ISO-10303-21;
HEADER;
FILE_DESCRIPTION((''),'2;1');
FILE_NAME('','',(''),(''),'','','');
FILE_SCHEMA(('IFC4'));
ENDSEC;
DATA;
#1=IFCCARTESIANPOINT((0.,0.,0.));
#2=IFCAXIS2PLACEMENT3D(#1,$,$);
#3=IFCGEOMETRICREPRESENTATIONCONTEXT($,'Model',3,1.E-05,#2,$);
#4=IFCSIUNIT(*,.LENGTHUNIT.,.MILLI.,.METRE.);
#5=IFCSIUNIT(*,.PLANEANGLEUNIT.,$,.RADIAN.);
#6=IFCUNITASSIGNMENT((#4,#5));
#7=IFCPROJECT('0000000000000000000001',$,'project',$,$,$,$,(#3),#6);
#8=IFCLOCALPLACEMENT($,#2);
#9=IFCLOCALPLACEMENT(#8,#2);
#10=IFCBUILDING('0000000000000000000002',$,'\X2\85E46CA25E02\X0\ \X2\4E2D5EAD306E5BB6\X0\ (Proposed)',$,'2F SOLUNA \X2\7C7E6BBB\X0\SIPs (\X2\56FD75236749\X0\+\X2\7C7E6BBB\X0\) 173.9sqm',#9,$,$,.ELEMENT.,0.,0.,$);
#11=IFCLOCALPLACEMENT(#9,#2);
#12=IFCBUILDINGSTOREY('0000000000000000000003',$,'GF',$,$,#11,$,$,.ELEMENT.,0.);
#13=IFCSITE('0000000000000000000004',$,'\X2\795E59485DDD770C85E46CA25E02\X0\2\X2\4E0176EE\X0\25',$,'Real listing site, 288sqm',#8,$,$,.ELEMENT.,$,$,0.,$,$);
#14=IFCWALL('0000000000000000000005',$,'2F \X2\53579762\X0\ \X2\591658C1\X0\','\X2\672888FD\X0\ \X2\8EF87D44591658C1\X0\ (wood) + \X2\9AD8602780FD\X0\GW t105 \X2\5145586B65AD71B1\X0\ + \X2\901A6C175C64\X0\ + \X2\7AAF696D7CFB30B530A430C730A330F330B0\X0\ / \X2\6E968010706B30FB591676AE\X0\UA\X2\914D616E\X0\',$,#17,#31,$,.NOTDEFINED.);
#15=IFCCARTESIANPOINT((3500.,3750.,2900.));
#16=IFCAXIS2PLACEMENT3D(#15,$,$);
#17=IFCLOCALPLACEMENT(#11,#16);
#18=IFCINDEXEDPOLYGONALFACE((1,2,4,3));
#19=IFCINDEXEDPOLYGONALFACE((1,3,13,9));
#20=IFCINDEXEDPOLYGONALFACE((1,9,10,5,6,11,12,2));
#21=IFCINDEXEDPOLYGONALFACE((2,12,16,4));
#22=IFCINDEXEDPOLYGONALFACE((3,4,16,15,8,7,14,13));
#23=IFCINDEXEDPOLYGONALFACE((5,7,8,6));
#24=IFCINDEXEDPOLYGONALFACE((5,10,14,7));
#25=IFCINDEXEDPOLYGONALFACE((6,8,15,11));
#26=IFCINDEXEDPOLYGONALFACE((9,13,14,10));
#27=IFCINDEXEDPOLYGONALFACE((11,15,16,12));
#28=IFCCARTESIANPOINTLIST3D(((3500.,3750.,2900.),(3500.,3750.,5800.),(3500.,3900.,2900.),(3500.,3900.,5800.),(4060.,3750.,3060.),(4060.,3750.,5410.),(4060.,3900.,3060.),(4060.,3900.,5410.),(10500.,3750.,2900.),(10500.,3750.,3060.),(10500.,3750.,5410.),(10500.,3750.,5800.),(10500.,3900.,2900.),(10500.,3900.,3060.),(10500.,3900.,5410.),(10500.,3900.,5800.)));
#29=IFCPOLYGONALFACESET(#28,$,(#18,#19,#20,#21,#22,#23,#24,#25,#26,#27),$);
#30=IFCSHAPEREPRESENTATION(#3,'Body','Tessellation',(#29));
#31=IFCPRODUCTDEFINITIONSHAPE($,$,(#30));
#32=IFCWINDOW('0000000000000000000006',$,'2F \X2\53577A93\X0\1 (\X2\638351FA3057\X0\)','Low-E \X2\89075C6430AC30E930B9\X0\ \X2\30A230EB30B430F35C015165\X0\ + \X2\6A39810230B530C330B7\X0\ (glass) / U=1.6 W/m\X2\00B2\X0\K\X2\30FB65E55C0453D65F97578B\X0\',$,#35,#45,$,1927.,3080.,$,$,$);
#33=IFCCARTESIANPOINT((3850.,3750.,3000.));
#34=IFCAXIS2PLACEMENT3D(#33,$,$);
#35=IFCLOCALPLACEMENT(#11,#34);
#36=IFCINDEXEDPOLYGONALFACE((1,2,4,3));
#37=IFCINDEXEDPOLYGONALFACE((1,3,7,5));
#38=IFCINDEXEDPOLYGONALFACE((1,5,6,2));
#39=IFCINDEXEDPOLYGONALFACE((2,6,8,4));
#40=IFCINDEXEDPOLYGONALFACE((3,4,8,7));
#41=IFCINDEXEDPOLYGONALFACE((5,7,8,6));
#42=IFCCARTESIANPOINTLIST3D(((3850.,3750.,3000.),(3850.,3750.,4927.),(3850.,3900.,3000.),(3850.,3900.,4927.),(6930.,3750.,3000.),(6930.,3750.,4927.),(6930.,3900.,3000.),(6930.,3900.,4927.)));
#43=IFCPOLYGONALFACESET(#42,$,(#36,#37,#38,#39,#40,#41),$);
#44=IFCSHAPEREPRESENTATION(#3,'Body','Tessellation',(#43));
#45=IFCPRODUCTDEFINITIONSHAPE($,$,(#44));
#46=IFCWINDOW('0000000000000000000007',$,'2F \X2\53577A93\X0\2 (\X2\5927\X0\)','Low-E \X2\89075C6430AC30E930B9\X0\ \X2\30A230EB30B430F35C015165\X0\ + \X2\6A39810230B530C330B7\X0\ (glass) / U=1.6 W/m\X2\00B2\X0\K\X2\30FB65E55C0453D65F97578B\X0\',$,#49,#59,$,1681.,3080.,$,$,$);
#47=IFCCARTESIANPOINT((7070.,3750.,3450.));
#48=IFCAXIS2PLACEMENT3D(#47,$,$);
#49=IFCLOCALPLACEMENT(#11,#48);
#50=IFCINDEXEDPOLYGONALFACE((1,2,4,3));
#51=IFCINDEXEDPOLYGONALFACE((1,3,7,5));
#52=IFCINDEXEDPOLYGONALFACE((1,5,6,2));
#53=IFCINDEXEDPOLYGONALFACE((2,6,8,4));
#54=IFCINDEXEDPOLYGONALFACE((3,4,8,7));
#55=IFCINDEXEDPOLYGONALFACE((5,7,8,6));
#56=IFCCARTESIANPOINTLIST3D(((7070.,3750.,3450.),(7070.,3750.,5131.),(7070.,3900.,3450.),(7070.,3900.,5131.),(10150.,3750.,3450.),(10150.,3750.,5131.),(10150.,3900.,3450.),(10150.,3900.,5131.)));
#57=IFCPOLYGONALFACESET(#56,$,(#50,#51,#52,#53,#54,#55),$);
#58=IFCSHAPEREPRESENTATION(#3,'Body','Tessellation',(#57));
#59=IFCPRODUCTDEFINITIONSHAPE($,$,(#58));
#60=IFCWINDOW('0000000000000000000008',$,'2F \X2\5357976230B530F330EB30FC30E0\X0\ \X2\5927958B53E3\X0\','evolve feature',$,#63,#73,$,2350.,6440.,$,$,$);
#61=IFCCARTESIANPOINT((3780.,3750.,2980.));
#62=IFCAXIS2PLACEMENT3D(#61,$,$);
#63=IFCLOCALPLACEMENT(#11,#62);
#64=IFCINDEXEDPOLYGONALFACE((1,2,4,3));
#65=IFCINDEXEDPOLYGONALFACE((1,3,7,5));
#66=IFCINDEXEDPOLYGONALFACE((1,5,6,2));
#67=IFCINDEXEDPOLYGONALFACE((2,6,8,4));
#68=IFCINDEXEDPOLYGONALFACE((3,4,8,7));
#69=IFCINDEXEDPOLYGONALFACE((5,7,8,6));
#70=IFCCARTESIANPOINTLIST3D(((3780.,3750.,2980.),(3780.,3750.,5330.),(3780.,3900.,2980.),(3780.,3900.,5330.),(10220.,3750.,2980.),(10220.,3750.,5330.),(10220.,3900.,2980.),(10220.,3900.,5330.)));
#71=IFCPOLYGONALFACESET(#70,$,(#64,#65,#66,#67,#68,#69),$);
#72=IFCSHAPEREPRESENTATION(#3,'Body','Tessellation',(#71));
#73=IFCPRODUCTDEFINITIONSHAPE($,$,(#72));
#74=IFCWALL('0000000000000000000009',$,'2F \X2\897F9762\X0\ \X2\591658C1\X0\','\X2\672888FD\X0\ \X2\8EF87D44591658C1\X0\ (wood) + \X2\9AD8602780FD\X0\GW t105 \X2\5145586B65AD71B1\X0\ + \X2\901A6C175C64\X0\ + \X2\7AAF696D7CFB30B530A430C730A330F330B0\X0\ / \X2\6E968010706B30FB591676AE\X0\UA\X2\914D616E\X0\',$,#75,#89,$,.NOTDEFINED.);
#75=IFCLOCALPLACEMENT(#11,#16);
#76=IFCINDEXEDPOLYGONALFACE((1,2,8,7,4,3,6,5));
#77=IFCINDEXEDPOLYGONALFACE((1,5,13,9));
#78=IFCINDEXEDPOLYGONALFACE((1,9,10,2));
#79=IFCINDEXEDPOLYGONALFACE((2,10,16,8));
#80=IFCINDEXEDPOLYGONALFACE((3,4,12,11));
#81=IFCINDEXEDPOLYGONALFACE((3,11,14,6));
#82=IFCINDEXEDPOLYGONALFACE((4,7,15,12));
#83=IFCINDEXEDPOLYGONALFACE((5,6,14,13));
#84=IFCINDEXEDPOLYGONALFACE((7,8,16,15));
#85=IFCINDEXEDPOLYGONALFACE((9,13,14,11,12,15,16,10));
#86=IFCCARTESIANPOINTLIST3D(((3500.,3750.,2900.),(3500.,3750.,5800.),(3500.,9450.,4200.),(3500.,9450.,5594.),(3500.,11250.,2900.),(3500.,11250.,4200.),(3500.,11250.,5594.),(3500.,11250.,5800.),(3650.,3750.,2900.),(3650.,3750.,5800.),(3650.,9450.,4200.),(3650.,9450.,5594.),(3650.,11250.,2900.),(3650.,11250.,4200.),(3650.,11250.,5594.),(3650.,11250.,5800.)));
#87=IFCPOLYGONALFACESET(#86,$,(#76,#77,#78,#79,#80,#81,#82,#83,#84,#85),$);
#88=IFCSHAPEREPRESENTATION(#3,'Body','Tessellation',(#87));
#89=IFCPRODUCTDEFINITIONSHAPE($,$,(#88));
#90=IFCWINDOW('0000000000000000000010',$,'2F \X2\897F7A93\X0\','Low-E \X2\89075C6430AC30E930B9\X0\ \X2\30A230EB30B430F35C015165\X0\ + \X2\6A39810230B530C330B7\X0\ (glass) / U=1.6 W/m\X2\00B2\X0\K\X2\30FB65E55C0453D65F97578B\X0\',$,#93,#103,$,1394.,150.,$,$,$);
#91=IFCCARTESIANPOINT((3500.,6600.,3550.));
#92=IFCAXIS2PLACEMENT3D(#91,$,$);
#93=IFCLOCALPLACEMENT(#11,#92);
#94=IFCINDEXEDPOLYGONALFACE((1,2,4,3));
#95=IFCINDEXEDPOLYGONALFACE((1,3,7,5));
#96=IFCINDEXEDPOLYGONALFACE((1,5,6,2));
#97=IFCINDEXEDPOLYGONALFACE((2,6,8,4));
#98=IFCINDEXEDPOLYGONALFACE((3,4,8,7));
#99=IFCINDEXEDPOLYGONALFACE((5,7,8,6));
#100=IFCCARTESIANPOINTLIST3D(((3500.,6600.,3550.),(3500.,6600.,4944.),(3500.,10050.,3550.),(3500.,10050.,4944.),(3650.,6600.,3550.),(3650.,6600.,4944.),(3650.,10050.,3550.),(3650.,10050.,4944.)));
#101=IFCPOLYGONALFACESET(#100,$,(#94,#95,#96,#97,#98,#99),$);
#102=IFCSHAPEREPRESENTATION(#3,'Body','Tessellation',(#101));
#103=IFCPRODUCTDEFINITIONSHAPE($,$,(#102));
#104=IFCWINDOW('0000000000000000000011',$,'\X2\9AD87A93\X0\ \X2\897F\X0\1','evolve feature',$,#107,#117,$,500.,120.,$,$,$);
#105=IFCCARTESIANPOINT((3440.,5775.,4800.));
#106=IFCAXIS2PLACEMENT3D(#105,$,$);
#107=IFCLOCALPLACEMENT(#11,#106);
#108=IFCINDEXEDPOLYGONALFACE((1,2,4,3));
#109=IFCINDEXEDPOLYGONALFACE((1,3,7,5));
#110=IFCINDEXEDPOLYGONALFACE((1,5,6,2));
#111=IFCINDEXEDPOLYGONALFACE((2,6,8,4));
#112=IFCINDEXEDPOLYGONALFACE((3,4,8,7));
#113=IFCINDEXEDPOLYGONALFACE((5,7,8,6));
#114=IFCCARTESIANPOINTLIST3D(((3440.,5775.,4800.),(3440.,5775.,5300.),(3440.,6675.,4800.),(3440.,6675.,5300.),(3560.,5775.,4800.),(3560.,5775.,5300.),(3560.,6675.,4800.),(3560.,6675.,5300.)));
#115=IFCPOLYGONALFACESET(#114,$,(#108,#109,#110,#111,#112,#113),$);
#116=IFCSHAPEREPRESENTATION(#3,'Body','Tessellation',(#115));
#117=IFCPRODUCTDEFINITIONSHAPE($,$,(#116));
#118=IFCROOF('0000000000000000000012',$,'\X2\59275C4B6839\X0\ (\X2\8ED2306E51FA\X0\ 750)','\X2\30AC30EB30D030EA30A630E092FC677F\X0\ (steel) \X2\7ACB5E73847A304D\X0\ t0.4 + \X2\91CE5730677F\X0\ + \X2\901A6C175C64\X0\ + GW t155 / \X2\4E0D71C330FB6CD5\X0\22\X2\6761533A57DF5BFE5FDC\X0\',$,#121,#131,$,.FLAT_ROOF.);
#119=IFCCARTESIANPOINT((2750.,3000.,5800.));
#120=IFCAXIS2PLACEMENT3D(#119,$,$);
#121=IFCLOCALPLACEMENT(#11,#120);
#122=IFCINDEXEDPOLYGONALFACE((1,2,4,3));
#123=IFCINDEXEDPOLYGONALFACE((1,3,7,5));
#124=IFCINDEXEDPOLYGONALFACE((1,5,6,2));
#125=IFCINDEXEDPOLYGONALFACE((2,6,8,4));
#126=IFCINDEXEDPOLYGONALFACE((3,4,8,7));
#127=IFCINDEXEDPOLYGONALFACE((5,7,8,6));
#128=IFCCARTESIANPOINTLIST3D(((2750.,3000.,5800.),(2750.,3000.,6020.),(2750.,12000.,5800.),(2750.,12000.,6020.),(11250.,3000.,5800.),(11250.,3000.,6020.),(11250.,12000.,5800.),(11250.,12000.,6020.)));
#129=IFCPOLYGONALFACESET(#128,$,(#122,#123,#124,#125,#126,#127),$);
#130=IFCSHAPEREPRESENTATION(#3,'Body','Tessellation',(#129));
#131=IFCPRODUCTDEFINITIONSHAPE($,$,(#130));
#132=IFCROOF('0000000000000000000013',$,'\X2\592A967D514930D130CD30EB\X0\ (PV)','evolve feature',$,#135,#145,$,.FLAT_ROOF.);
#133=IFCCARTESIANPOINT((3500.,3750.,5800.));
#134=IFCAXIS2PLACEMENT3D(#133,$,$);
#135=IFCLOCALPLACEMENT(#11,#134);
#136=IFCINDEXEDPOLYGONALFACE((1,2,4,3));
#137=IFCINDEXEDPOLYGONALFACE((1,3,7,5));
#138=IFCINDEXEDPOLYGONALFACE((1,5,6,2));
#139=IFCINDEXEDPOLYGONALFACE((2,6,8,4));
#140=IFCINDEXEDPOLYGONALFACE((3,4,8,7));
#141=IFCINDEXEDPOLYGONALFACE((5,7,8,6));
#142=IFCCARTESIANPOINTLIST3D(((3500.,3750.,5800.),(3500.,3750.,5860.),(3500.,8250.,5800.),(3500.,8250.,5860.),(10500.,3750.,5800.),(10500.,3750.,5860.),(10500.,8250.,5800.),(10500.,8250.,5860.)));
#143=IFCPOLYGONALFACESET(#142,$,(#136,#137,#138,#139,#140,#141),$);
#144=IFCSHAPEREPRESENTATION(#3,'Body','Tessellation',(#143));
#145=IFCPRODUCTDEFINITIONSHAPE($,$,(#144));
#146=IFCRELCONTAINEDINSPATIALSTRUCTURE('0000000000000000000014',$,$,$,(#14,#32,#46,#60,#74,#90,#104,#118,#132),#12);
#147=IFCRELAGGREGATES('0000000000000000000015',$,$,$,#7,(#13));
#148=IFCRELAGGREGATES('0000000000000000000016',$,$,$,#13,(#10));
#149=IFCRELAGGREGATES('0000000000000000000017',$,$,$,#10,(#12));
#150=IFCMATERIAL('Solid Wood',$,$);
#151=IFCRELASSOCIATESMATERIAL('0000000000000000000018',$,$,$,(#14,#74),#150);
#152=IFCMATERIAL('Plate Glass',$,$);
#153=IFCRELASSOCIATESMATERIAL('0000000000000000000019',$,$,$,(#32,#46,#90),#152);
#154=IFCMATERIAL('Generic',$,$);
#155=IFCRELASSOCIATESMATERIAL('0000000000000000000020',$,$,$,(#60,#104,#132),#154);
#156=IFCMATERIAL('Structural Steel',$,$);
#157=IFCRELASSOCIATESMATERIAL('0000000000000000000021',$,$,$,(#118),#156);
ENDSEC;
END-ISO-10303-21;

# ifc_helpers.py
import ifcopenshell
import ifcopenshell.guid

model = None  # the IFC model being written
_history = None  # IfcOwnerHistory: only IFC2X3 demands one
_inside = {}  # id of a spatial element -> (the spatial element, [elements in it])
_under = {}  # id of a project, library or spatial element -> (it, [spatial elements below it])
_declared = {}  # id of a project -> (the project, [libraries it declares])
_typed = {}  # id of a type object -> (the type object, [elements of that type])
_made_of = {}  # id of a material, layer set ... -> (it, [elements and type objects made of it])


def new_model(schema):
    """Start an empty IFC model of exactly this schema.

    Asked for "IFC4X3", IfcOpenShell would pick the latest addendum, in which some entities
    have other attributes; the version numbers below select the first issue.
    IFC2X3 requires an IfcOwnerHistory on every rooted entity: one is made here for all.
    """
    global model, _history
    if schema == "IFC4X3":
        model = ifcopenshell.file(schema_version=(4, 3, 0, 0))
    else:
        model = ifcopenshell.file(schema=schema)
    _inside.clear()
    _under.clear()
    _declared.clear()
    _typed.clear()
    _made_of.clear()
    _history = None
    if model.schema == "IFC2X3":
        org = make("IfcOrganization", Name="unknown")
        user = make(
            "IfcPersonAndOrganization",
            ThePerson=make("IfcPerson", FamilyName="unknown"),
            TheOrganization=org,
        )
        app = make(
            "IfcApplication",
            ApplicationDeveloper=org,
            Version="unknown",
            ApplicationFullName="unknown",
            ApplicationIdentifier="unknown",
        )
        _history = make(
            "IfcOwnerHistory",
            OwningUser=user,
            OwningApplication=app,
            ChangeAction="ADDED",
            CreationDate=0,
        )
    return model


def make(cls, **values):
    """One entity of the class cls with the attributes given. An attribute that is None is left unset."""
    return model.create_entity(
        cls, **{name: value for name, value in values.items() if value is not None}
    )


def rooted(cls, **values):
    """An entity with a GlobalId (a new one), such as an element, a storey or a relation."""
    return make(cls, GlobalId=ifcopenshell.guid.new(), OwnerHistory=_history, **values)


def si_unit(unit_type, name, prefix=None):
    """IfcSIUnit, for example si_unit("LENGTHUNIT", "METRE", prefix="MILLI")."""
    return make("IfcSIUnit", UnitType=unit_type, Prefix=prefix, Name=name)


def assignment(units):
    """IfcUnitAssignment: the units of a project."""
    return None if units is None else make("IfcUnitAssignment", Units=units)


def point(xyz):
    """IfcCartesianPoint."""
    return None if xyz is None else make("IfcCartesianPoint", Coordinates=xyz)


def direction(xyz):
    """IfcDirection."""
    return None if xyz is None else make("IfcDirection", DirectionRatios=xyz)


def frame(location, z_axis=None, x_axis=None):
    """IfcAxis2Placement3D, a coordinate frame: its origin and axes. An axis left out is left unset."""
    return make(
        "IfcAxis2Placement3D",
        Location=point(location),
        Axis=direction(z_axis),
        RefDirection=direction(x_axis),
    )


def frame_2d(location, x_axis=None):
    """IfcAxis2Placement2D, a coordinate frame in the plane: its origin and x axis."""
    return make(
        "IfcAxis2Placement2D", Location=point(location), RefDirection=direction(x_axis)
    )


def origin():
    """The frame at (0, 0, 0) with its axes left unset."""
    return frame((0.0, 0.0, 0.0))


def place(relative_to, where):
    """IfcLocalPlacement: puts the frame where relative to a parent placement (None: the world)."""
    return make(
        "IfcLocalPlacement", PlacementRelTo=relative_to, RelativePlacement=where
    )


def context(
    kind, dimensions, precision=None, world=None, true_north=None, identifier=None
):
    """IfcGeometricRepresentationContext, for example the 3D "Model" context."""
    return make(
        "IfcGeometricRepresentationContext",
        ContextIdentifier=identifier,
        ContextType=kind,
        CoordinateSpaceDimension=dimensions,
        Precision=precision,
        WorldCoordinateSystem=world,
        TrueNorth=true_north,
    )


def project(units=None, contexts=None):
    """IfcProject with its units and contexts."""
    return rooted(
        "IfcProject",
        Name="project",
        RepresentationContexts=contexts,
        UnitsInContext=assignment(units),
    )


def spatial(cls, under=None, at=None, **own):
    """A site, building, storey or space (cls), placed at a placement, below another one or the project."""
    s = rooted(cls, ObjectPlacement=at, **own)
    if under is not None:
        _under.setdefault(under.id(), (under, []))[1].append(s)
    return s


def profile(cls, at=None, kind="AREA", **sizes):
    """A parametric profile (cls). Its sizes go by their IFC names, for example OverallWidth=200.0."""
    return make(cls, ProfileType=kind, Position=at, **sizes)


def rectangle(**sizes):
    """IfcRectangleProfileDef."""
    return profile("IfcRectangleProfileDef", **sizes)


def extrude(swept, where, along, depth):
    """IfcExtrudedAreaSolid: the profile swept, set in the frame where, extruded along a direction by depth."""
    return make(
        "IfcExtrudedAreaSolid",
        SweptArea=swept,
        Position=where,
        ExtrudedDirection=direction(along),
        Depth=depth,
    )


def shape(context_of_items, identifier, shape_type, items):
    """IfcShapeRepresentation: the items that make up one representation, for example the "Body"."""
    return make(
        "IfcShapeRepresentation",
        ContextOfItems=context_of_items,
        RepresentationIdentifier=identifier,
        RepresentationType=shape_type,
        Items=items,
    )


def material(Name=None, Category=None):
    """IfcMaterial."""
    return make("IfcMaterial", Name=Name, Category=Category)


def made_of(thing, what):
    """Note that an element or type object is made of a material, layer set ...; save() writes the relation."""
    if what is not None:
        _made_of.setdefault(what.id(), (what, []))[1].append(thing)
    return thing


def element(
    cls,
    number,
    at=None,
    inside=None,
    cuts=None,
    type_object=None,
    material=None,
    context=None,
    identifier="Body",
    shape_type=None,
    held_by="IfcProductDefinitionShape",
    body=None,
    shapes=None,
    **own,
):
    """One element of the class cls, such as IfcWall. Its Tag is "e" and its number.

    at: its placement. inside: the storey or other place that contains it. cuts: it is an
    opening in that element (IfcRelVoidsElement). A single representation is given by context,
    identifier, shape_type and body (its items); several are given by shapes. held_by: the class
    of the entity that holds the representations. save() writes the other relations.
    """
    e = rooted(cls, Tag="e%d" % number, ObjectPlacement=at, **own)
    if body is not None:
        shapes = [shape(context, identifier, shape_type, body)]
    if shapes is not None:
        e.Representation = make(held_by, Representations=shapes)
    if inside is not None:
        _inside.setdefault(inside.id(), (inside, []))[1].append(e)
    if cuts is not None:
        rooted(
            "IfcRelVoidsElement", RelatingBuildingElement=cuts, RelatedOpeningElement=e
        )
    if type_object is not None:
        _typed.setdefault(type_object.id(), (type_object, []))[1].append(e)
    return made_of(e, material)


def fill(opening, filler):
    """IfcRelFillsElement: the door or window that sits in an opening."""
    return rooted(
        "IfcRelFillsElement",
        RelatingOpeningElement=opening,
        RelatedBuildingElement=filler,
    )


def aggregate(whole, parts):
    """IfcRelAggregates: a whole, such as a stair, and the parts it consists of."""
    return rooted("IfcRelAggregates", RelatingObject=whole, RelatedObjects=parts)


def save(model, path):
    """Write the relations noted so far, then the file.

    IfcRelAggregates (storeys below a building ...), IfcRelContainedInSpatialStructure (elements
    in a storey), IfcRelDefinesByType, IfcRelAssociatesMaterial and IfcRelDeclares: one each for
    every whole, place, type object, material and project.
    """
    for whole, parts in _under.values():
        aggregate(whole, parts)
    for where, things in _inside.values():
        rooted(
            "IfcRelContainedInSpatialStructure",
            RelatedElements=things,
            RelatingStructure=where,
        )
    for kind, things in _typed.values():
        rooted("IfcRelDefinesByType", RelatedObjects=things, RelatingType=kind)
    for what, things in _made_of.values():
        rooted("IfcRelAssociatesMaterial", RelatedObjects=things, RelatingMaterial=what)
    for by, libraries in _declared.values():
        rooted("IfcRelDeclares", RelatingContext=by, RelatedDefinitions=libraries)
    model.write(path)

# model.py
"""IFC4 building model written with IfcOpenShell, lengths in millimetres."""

from ifc_helpers import new_model, si_unit, frame, frame_2d, origin, place, context, project, spatial, rectangle, extrude, material, element, fill, save


model = new_model("IFC4")

# Units and contexts
model_context = context("Model", 3, precision=1e-05, world=origin())
ifc_project = project(units=[si_unit("LENGTHUNIT", "METRE", prefix="MILLI"), si_unit("PLANEANGLEUNIT", "RADIAN")], contexts=[model_context])

# Site, building, storey
site_placement = place(None, origin())
site = spatial("IfcSite", under=ifc_project, at=site_placement, Name="神奈川県藤沢市2丁目25", ObjectType="Real listing site, 288sqm", CompositionType="ELEMENT", RefElevation=0.0)
building_placement = place(site_placement, origin())
building = spatial("IfcBuilding", under=site, at=building_placement, Name="藤沢市 中庭の家 (Proposed)", ObjectType="2F SOLUNA 籾殻SIPs (国産杉+籾殻) 173.9sqm", CompositionType="ELEMENT", ElevationOfRefHeight=0.0, ElevationOfTerrain=0.0)
storey_placement = place(building_placement, origin())
storey = spatial("IfcBuildingStorey", under=building, at=storey_placement, Name="GF", CompositionType="ELEMENT", Elevation=0.0)

# Shared definitions
ifc_material_1 = material(Name="Solid Wood")
ifc_material_2 = material(Name="Generic")

# Shared definitions
ifc_material_3 = material(Name="Plate Glass")

# Walls, openings, windows
wall_1_placement = place(storey_placement, frame((3500.0, 3750.0, 2900.0)))
wall_1 = element("IfcWall", 1, at=wall_1_placement, inside=storey, material=ifc_material_1, Name="2F 南面 外壁", Description="木製 軸組外壁 (wood) + 高性能GW t105 充填断熱 + 通気層 + 窯業系サイディング / 準耐火・外皮UA配慮", PredefinedType="NOTDEFINED", context=model_context, shape_type="SweptSolid", body=[
    extrude(rectangle(XDim=7000.0, YDim=150.0, at=frame_2d((3500.0, 75.0))), frame((3500.0, 3750.0, 2900.0)), (0.0, 0.0, 1.0), 2900.0),
])
opening_1_placement = place(storey_placement, frame((3850.0, 3750.0, 3000.0)))
opening_1 = element("IfcOpeningElement", 2, at=opening_1_placement, cuts=wall_1, PredefinedType="NOTDEFINED", context=model_context, shape_type="SweptSolid", body=[
    extrude(rectangle(XDim=3080.0, YDim=150.0, at=frame_2d((1540.0, 75.0))), frame((3850.0, 3750.0, 3000.0)), (0.0, 0.0, 1.0), 1927.0),
])
opening_2_placement = place(storey_placement, frame((7070.0, 3750.0, 3450.0)))
opening_2 = element("IfcOpeningElement", 3, at=opening_2_placement, cuts=wall_1, PredefinedType="NOTDEFINED", context=model_context, shape_type="SweptSolid", body=[
    extrude(rectangle(XDim=3080.0, YDim=150.0, at=frame_2d((1540.0, 75.0))), frame((7070.0, 3750.0, 3450.0)), (0.0, 0.0, 1.0), 1681.0),
])
opening_3_placement = place(storey_placement, frame((3780.0, 3750.0, 2980.0)))
opening_3 = element("IfcOpeningElement", 4, at=opening_3_placement, cuts=wall_1, PredefinedType="NOTDEFINED", context=model_context, shape_type="SweptSolid", body=[
    extrude(rectangle(XDim=6440.0, YDim=150.0, at=frame_2d((3220.0, 75.0))), frame((3780.0, 3750.0, 2980.0)), (0.0, 0.0, 1.0), 2350.0),
])
window_1_placement = place(storey_placement, frame((3850.0, 3750.0, 3000.0)))
window_1 = element("IfcWindow", 5, at=window_1_placement, inside=storey, material=ifc_material_3, Name="2F 南窓1 (掃出し)", Description="Low-E 複層ガラス アルゴン封入 + 樹脂サッシ (glass) / U=1.6 W/m²K・日射取得型", OverallHeight=1927.0, OverallWidth=3080.0, context=model_context, shape_type="SweptSolid", body=[
    extrude(rectangle(XDim=3080.0, YDim=150.0, at=frame_2d((1540.0, 75.0))), frame((3850.0, 3750.0, 3000.0)), (0.0, 0.0, 1.0), 1927.0),
])
fill(opening_1, window_1)
window_2_placement = place(storey_placement, frame((7070.0, 3750.0, 3450.0)))
window_2 = element("IfcWindow", 6, at=window_2_placement, inside=storey, material=ifc_material_3, Name="2F 南窓2 (大)", Description="Low-E 複層ガラス アルゴン封入 + 樹脂サッシ (glass) / U=1.6 W/m²K・日射取得型", OverallHeight=1681.0, OverallWidth=3080.0, context=model_context, shape_type="SweptSolid", body=[
    extrude(rectangle(XDim=3080.0, YDim=150.0, at=frame_2d((1540.0, 75.0))), frame((7070.0, 3750.0, 3450.0)), (0.0, 0.0, 1.0), 1681.0),
])
fill(opening_2, window_2)
window_3_placement = place(storey_placement, frame((3780.0, 3750.0, 2980.0)))
window_3 = element("IfcWindow", 7, at=window_3_placement, inside=storey, material=ifc_material_2, Name="2F 南面サンルーム 大開口", Description="evolve feature", OverallHeight=2350.0, OverallWidth=6440.0, context=model_context, shape_type="SweptSolid", body=[
    extrude(rectangle(XDim=6440.0, YDim=150.0, at=frame_2d((3220.0, 75.0))), frame((3780.0, 3750.0, 2980.0)), (0.0, 0.0, 1.0), 2350.0),
])
fill(opening_3, window_3)
wall_2_placement = place(storey_placement, frame((3500.0, 3750.0, 2900.0)))
wall_2 = element("IfcWall", 8, at=wall_2_placement, inside=storey, material=ifc_material_1, Name="2F 西面 外壁", Description="木製 軸組外壁 (wood) + 高性能GW t105 充填断熱 + 通気層 + 窯業系サイディング / 準耐火・外皮UA配慮", PredefinedType="NOTDEFINED", context=model_context, shape_type="SweptSolid", body=[
    extrude(rectangle(XDim=150.0, YDim=7500.0, at=frame_2d((75.0, 3750.0))), frame((3500.0, 3750.0, 2900.0)), (0.0, 0.0, 1.0), 2900.0),
])
opening_4_placement = place(storey_placement, frame((3500.0, 6600.0, 3550.0)))
opening_4 = element("IfcOpeningElement", 9, at=opening_4_placement, cuts=wall_2, PredefinedType="NOTDEFINED", context=model_context, shape_type="SweptSolid", body=[
    extrude(rectangle(XDim=150.0, YDim=3450.0, at=frame_2d((75.0, 1725.0))), frame((3500.0, 6600.0, 3550.0)), (0.0, 0.0, 1.0), 1394.0),
])
opening_5_placement = place(storey_placement, frame((3440.0, 5775.0, 4800.0)))
opening_5 = element("IfcOpeningElement", 10, at=opening_5_placement, cuts=wall_2, PredefinedType="NOTDEFINED", context=model_context, shape_type="SweptSolid", body=[
    extrude(rectangle(XDim=120.0, YDim=900.0, at=frame_2d((60.0, 450.0))), frame((3440.0, 5775.0, 4800.0)), (0.0, 0.0, 1.0), 500.0),
])
window_4_placement = place(storey_placement, frame((3500.0, 6600.0, 3550.0)))
window_4 = element("IfcWindow", 11, at=window_4_placement, inside=storey, material=ifc_material_3, Name="2F 西窓", Description="Low-E 複層ガラス アルゴン封入 + 樹脂サッシ (glass) / U=1.6 W/m²K・日射取得型", OverallHeight=1394.0, OverallWidth=150.0, context=model_context, shape_type="SweptSolid", body=[
    extrude(rectangle(XDim=150.0, YDim=3450.0, at=frame_2d((75.0, 1725.0))), frame((3500.0, 6600.0, 3550.0)), (0.0, 0.0, 1.0), 1394.0),
])
fill(opening_4, window_4)
window_5_placement = place(storey_placement, frame((3440.0, 5775.0, 4800.0)))
window_5 = element("IfcWindow", 12, at=window_5_placement, inside=storey, material=ifc_material_2, Name="高窓 西1", Description="evolve feature", OverallHeight=500.0, OverallWidth=120.0, context=model_context, shape_type="SweptSolid", body=[
    extrude(rectangle(XDim=120.0, YDim=900.0, at=frame_2d((60.0, 450.0))), frame((3440.0, 5775.0, 4800.0)), (0.0, 0.0, 1.0), 500.0),
])
fill(opening_5, window_5)

# Roofs
ifc_material_4 = material(Name="Structural Steel")
roof_1_placement = place(storey_placement, frame((2750.0, 3000.0, 5800.0)))
element("IfcRoof", 13, at=roof_1_placement, inside=storey, material=ifc_material_4, Name="大屋根 (軒の出 750)", Description="ガルバリウム鋼板 (steel) 立平葺き t0.4 + 野地板 + 通気層 + GW t155 / 不燃・法22条区域対応", PredefinedType="FLAT_ROOF", context=model_context, shape_type="SweptSolid", body=[
    extrude(rectangle(XDim=8500.0, YDim=9000.0, at=frame_2d((4250.0, 4500.0))), frame((2750.0, 3000.0, 5800.0)), (0.0, 0.0, 1.0), 220.0),
])
roof_2_placement = place(storey_placement, frame((3500.0, 3750.0, 5800.0)))
element("IfcRoof", 14, at=roof_2_placement, inside=storey, material=ifc_material_2, Name="太陽光パネル (PV)", Description="evolve feature", PredefinedType="FLAT_ROOF", context=model_context, shape_type="SweptSolid", body=[
    extrude(rectangle(XDim=7000.0, YDim=4500.0, at=frame_2d((3500.0, 2250.0))), frame((3500.0, 3750.0, 5800.0)), (0.0, 0.0, 1.0), 60.0),
])

save(model, "model.ifc")
